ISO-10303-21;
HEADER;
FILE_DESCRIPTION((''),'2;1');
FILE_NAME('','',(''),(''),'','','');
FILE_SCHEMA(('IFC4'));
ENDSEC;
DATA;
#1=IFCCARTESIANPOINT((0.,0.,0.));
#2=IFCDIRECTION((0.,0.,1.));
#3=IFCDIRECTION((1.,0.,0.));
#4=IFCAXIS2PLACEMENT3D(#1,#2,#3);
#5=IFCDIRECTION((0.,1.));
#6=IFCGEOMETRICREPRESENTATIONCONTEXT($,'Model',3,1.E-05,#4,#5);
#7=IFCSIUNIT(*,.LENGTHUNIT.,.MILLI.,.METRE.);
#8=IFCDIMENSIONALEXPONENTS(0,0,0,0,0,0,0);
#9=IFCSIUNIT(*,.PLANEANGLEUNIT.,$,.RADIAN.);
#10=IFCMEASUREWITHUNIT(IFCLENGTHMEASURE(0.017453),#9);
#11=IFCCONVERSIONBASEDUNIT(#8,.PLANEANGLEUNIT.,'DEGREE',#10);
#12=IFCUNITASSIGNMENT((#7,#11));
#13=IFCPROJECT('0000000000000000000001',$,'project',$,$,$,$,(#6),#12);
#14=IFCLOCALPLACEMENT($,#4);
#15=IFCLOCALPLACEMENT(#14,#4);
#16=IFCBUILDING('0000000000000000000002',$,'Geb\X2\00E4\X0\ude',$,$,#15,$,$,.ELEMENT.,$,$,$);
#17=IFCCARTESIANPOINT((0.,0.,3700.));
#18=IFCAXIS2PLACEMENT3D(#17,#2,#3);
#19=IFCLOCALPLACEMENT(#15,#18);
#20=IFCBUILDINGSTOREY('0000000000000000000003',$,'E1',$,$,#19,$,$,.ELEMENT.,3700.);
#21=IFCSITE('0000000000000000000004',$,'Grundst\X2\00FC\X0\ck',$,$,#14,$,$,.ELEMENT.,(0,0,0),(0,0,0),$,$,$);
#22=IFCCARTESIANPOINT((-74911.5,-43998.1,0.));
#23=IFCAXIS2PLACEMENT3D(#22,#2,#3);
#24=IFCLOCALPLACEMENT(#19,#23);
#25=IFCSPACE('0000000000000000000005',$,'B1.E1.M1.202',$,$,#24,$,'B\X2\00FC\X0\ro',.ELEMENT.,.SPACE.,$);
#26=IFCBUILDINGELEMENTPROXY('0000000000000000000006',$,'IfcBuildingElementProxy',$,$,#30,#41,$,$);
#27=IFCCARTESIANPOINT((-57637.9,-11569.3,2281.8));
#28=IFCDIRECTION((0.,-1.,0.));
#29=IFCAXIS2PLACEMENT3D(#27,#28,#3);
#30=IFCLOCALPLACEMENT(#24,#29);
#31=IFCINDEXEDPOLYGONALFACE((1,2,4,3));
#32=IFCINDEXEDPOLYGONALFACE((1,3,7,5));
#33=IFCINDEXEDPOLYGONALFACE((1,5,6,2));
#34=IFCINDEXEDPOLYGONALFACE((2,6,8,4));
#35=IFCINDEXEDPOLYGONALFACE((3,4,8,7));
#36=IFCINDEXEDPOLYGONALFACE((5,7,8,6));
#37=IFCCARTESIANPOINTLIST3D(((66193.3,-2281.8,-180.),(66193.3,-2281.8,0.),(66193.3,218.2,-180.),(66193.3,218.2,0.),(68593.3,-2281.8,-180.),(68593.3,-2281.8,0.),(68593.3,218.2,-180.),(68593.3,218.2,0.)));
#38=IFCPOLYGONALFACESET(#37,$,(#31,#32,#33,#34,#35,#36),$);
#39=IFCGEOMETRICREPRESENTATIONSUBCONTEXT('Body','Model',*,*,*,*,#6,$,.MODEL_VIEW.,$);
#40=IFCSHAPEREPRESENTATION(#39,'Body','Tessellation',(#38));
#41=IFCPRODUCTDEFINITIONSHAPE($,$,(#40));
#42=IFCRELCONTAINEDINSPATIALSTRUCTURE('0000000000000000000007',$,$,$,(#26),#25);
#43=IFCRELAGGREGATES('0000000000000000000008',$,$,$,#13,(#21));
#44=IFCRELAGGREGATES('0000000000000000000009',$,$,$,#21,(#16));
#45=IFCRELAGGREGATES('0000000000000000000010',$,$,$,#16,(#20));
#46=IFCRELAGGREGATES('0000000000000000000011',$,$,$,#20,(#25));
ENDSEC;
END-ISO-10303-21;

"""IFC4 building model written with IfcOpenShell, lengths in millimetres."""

from ifc_helpers import new_model, entity, si_unit, converted_unit, direction, frame, origin_with_axes, place, context, subcontext, project, spatial, line, indexed_curve, outline, extrude, element, save


model = new_model("IFC4")

# Units and contexts
model_context = context("Model", 3, precision=1e-05, world=origin_with_axes(), true_north=direction((0.0, 1.0)))
body_context = subcontext(model_context, "Body", "Model", "MODEL_VIEW")
ifc_project = project(units=[si_unit("LENGTHUNIT", "METRE", prefix="MILLI"), converted_unit("PLANEANGLEUNIT", "DEGREE", entity("IfcLengthMeasure", 0.017453), si_unit("PLANEANGLEUNIT", "RADIAN"), dimensions=[0, 0, 0, 0, 0, 0, 0])], contexts=[model_context])

# Site, building, storey
site_placement = place(None, origin_with_axes())
site = spatial("IfcSite", under=ifc_project, at=site_placement, Name="Grundstück", CompositionType="ELEMENT", RefLatitude=(0, 0, 0), RefLongitude=(0, 0, 0))
building_placement = place(site_placement, origin_with_axes())
building = spatial("IfcBuilding", under=site, at=building_placement, Name="Gebäude", CompositionType="ELEMENT")
storey_placement = place(building_placement, frame((0.0, 0.0, 3700.0), z_axis=(0.0, 0.0, 1.0), x_axis=(1.0, 0.0, 0.0)))
storey = spatial("IfcBuildingStorey", under=building, at=storey_placement, Name="E1", CompositionType="ELEMENT", Elevation=3700.0)

# Shared definitions
space_placement = place(storey_placement, frame((-74911.5, -43998.1, 0.0), z_axis=(0.0, 0.0, 1.0), x_axis=(1.0, 0.0, 0.0)))
space = spatial("IfcSpace", under=storey, at=space_placement, Name="B1.E1.M1.202", LongName="Büro", CompositionType="ELEMENT", PredefinedType="SPACE")

# Building element proxy
proxy_placement = place(space_placement, frame((-57637.9, -11569.3, 2281.8), z_axis=(0.0, -1.0, 0.0), x_axis=(1.0, 0.0, 0.0)))
element("IfcBuildingElementProxy", 1, at=proxy_placement, inside=space, Name="IfcBuildingElementProxy", context=body_context, shape_type="SweptSolid", body=[
    extrude(outline(indexed_curve([(66193.3, -2281.8), (68593.3, -2281.8), (68593.3, 218.2), (66193.3, 218.2)], segments=[line(1, 2), line(2, 3), line(3, 4), line(4, 1)])), origin_with_axes(), (0.0, 0.0, -1.0), 180.0),
])

save(model, "model.ifc")
